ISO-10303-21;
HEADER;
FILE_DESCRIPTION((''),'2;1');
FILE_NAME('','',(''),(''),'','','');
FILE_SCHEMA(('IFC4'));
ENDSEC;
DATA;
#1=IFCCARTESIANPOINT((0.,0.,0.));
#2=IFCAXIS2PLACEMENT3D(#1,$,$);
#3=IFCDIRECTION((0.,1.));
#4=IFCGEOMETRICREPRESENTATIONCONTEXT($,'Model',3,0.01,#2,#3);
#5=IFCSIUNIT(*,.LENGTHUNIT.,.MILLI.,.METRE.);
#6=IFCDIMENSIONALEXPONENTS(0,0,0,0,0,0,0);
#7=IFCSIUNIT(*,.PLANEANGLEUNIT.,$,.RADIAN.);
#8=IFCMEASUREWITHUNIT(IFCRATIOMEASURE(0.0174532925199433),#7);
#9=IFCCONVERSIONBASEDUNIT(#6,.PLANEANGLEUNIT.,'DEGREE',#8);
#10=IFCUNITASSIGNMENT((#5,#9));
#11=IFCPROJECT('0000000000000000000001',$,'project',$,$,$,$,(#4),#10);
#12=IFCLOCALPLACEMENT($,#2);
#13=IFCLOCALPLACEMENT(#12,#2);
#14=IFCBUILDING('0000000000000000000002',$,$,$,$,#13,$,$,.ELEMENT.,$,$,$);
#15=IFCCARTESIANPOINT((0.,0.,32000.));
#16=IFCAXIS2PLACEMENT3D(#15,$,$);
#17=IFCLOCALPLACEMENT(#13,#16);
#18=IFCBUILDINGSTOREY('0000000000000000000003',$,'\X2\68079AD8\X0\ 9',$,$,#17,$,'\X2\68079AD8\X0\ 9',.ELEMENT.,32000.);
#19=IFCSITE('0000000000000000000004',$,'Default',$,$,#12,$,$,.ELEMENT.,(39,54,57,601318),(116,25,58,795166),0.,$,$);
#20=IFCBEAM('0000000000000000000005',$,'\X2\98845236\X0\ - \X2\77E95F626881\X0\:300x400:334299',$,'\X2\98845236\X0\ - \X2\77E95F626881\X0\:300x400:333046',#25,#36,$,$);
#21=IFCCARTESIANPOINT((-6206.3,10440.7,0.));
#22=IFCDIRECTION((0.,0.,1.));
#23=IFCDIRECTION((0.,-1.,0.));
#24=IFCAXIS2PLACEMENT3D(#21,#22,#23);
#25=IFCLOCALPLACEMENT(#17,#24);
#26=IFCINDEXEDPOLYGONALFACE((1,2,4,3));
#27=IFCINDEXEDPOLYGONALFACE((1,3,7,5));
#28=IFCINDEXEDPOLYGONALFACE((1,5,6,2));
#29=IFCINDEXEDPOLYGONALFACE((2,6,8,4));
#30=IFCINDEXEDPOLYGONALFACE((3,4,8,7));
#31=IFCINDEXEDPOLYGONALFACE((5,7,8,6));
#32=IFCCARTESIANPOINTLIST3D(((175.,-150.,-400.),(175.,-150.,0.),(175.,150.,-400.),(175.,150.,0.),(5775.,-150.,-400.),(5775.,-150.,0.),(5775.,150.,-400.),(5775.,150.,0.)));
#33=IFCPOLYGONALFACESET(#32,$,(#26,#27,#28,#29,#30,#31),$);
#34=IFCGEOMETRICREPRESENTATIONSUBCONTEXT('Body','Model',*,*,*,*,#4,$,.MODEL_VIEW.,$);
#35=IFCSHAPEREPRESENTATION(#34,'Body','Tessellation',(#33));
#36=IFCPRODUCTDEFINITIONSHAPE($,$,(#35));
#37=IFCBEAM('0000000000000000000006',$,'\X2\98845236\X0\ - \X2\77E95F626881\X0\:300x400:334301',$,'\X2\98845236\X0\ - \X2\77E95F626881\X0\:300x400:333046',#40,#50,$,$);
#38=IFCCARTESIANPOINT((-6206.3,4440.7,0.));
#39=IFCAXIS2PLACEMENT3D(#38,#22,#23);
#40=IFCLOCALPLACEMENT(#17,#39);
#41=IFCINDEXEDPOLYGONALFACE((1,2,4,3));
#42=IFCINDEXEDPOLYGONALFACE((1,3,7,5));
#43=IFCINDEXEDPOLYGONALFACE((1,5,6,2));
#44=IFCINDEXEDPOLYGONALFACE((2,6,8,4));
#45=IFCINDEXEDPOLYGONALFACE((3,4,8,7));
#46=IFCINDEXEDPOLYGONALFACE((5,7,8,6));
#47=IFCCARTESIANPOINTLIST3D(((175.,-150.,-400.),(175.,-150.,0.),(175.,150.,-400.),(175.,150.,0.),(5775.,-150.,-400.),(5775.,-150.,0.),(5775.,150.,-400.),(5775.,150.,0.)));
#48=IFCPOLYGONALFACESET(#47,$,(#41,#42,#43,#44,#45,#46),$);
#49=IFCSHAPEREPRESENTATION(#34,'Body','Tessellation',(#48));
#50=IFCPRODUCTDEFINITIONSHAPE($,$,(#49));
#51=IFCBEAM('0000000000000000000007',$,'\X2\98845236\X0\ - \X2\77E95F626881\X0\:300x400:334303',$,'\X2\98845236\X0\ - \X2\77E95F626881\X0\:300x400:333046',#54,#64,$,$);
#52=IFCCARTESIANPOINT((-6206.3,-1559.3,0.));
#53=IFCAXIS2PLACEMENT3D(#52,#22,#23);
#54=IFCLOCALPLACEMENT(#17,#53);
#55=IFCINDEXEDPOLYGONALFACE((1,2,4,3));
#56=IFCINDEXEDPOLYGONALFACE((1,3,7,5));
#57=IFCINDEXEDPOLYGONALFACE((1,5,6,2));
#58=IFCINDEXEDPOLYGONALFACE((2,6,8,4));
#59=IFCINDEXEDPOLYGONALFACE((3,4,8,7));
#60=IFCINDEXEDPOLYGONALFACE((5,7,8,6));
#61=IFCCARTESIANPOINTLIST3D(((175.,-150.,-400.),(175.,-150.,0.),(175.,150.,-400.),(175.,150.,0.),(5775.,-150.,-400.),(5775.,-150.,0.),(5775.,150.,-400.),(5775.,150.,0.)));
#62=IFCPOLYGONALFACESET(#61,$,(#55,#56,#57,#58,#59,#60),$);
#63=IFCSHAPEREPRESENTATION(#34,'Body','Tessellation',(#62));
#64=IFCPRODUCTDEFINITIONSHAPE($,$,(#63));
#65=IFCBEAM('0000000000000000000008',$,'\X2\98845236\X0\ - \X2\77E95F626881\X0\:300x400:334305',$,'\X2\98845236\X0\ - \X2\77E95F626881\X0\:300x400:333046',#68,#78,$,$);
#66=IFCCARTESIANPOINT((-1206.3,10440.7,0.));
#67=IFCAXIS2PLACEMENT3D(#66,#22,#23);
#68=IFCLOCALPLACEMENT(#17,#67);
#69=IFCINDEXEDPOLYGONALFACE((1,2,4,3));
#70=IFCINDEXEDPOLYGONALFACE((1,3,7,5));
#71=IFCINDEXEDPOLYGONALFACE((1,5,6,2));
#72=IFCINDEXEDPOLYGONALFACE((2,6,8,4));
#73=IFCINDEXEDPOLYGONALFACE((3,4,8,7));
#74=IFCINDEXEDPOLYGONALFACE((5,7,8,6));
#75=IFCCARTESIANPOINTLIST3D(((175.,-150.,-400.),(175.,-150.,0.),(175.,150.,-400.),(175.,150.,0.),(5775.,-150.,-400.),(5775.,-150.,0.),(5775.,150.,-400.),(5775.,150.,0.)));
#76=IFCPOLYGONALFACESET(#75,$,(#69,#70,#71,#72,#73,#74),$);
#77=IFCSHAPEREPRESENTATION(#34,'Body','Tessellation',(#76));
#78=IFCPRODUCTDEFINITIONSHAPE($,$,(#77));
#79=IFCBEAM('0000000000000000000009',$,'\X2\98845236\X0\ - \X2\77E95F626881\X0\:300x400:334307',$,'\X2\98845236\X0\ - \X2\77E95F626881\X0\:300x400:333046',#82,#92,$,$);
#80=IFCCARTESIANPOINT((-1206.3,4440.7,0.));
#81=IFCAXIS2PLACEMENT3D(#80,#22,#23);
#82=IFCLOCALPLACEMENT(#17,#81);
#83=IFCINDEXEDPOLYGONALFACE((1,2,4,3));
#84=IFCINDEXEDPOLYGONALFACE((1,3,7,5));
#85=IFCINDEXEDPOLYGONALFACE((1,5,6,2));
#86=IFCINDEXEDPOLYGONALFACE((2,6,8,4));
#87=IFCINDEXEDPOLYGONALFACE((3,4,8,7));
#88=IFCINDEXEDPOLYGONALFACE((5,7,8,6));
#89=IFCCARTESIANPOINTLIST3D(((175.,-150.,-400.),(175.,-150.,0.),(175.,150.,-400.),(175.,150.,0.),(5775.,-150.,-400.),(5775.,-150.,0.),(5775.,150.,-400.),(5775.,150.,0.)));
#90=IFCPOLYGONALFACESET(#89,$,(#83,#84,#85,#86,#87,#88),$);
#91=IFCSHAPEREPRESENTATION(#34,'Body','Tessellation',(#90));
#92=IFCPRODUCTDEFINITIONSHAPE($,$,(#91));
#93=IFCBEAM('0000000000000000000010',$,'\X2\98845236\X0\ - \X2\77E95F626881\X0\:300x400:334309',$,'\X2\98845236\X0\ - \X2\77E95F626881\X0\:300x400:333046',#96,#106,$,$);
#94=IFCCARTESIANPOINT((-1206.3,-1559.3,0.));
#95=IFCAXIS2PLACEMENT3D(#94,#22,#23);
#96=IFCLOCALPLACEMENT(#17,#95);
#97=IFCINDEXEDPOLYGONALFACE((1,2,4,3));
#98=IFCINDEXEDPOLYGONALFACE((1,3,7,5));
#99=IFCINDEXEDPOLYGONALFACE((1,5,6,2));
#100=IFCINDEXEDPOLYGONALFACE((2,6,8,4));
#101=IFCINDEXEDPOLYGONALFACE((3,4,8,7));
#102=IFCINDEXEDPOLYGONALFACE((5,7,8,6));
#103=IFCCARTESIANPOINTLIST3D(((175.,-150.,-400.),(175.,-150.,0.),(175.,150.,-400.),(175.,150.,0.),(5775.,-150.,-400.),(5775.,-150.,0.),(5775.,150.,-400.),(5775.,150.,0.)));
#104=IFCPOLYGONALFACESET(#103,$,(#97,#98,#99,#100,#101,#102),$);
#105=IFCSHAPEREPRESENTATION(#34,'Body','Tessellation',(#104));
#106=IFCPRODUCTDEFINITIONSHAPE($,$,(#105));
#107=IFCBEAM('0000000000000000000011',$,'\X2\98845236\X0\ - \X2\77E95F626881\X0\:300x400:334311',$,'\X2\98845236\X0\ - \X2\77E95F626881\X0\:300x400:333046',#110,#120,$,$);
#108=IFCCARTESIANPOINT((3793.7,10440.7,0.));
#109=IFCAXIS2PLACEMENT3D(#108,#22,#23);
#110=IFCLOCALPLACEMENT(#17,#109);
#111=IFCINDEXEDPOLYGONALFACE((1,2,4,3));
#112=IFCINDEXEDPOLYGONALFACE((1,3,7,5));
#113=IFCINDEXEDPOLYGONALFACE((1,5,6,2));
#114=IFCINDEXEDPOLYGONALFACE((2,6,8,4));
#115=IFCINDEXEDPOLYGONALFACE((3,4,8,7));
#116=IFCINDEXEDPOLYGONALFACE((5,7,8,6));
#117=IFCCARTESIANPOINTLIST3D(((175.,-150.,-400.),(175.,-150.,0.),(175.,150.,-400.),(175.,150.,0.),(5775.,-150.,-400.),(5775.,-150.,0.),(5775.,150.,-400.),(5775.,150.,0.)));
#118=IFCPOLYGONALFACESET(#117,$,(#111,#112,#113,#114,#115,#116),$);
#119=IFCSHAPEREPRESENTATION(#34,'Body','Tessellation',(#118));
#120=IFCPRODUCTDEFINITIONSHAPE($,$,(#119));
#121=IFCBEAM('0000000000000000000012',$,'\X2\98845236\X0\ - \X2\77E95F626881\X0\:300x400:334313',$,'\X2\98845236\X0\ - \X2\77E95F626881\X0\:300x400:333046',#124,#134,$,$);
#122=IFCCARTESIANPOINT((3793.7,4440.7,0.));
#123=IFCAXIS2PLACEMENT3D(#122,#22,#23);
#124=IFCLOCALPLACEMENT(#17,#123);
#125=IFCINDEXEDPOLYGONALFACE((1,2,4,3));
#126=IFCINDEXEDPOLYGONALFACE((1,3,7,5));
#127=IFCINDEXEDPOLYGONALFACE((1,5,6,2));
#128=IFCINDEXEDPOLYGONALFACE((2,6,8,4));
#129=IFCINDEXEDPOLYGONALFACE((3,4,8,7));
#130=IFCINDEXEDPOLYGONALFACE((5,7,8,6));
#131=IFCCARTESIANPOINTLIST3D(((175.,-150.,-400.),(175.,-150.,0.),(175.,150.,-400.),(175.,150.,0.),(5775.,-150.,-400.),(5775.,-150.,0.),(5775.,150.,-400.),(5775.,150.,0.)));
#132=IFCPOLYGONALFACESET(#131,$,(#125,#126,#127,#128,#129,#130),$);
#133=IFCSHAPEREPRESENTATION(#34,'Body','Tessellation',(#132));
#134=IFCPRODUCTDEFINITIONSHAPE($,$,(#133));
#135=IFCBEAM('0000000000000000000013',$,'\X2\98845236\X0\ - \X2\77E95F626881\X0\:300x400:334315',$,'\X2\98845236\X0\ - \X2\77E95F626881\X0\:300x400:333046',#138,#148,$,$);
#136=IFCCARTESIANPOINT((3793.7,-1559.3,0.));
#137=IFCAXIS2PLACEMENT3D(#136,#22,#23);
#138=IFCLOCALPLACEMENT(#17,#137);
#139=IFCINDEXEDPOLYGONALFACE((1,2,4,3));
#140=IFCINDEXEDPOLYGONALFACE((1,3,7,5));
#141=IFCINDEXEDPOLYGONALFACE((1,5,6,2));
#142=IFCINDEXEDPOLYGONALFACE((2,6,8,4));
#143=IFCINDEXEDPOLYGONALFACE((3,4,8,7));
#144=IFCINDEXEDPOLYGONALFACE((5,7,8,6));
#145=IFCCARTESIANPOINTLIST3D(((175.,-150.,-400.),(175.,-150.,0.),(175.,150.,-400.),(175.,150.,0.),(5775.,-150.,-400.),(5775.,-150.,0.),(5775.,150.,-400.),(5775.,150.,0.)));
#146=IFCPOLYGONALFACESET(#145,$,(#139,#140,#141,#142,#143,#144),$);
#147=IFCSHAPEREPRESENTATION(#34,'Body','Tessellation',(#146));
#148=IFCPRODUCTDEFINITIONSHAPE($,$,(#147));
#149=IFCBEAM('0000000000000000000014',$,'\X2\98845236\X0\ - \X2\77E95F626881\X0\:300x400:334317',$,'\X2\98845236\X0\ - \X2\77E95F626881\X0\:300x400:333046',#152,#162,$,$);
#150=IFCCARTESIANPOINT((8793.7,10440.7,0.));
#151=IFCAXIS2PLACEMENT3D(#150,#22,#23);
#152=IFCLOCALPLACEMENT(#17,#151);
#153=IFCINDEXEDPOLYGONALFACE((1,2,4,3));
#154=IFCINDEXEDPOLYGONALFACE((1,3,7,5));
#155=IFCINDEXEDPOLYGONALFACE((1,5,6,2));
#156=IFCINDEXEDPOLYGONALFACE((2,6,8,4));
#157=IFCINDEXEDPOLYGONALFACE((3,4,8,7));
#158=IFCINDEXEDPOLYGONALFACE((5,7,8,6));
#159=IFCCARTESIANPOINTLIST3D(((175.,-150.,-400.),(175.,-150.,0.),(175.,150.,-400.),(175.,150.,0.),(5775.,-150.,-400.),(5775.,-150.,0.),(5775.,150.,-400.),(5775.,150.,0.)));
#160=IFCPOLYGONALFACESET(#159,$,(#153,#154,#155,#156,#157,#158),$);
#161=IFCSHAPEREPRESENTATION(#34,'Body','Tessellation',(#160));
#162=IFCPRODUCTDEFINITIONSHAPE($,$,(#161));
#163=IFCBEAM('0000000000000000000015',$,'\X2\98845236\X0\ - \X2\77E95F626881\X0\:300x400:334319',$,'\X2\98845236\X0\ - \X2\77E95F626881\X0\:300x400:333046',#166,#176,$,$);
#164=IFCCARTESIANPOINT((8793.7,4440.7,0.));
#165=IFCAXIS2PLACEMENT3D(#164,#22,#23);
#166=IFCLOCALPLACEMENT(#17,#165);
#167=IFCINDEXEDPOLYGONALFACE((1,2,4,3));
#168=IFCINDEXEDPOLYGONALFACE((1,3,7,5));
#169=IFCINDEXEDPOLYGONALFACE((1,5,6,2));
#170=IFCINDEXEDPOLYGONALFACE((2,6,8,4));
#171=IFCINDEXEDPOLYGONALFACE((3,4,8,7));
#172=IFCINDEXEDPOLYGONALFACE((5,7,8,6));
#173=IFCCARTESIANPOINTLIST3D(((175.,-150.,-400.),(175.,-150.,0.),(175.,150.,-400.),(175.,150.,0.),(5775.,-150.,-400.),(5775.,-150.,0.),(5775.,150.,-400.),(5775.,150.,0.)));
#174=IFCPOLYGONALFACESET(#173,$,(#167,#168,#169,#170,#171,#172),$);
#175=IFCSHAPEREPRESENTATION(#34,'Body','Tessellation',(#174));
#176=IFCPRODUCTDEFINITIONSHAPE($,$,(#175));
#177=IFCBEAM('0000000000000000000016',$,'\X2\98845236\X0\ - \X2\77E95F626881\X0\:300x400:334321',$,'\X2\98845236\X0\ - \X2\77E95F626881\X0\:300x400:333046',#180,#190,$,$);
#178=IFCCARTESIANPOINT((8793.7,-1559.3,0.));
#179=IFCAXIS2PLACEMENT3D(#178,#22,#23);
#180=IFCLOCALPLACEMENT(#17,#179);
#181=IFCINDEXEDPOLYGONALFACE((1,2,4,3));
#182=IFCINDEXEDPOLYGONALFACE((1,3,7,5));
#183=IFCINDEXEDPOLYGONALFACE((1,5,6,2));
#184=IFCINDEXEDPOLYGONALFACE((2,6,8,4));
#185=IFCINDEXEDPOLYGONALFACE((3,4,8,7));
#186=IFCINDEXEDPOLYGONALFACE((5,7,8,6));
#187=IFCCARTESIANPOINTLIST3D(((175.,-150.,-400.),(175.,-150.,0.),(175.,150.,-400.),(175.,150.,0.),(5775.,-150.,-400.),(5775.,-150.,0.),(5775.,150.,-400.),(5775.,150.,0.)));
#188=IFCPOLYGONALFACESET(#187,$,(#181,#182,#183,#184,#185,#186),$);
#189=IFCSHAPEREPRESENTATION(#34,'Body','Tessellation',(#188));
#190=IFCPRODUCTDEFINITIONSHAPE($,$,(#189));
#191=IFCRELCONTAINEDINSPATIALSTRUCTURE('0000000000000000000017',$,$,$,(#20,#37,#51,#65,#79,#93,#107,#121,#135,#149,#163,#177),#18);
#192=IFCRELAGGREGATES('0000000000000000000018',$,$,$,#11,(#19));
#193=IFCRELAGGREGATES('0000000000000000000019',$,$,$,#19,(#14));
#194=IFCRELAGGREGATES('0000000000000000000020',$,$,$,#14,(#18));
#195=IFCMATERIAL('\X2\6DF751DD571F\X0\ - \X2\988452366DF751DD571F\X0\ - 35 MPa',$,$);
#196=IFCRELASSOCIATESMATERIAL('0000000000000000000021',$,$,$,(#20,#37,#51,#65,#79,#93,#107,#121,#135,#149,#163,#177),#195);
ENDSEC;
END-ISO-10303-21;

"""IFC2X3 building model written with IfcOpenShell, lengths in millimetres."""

from ifc_helpers import new_model, entity, si_unit, converted_unit, direction, frame, frame_2d, origin, origin_2d_with_axis, place, context, subcontext, project, spatial, rectangle, extrude, material, element, save


model = new_model("IFC2X3")

# Units and contexts
model_context = context("Model", 3, precision=0.01, world=origin(), true_north=direction((0.0, 1.0)))
body_context = subcontext(model_context, "Body", "Model", "MODEL_VIEW")
ifc_project = project(units=[si_unit("LENGTHUNIT", "METRE", prefix="MILLI"), converted_unit("PLANEANGLEUNIT", "DEGREE", entity("IfcRatioMeasure", 0.0174532925199433), si_unit("PLANEANGLEUNIT", "RADIAN"), dimensions=[0, 0, 0, 0, 0, 0, 0])], contexts=[model_context])

# Site, building, storey
site_placement = place(None, origin())
site = spatial("IfcSite", under=ifc_project, at=site_placement, Name="Default", CompositionType="ELEMENT", RefLatitude=(39, 54, 57, 601318), RefLongitude=(116, 25, 58, 795166), RefElevation=0.0)
building_placement = place(site_placement, origin())
building = spatial("IfcBuilding", under=site, at=building_placement, CompositionType="ELEMENT")
storey_placement = place(building_placement, frame((0.0, 0.0, 32000.0)))
storey = spatial("IfcBuildingStorey", under=building, at=storey_placement, Name="标高 9", LongName="标高 9", CompositionType="ELEMENT", Elevation=32000.0)

# Beams
ifc_material_1 = material(Name="混凝土 - 预制混凝土 - 35 MPa")
for number, where, z_axis, x_axis, name in (
    (1, (-6206.3, 10440.7, 0.0), (0.0, 0.0, 1.0), (0.0, -1.0, 0.0), "预制 - 矩形梁:300x400:334299"),
    (2, (-6206.3, 4440.7, 0.0), (0.0, 0.0, 1.0), (0.0, -1.0, 0.0), "预制 - 矩形梁:300x400:334301"),
    (3, (-6206.3, -1559.3, 0.0), (0.0, 0.0, 1.0), (0.0, -1.0, 0.0), "预制 - 矩形梁:300x400:334303"),
):
    element("IfcBeam", number, at=place(storey_placement, frame(where, z_axis=z_axis, x_axis=x_axis)), inside=storey, material=ifc_material_1, Name=name, ObjectType="预制 - 矩形梁:300x400:333046", context=body_context, shape_type="SweptSolid", body=[
        extrude(rectangle(XDim=400.0, YDim=300.0, at=origin_2d_with_axis()), frame((175.0, 0.0, -200.0), z_axis=(1.0, 0.0, 0.0), x_axis=(0.0, 0.0, -1.0)), (0.0, 0.0, 1.0), 5600.0),
    ])
beam_1_placement = place(storey_placement, frame((-1206.3, 10440.7, 0.0), z_axis=(0.0, 0.0, 1.0), x_axis=(0.0, -1.0, 0.0)))
element("IfcBeam", 4, at=beam_1_placement, inside=storey, material=ifc_material_1, Name="预制 - 矩形梁:300x400:334305", ObjectType="预制 - 矩形梁:300x400:333046", context=body_context, shape_type="SweptSolid", body=[
    extrude(rectangle(XDim=400.0, YDim=300.0, at=frame_2d((0.0, 0.0), x_axis=(1.0, 0.0))), frame((175.0, 0.0, -200.0), z_axis=(1.0, 0.0, 0.0), x_axis=(0.0, 0.0, -1.0)), (0.0, 0.0, 1.0), 5600.0),
])
beam_2_placement = place(storey_placement, frame((-1206.3, 4440.7, 0.0), z_axis=(0.0, 0.0, 1.0), x_axis=(0.0, -1.0, 0.0)))
element("IfcBeam", 5, at=beam_2_placement, inside=storey, material=ifc_material_1, Name="预制 - 矩形梁:300x400:334307", ObjectType="预制 - 矩形梁:300x400:333046", context=body_context, shape_type="SweptSolid", body=[
    extrude(rectangle(XDim=400.0, YDim=300.0, at=frame_2d((0.0, 0.0), x_axis=(1.0, 0.0))), frame((175.0, 0.0, -200.0), z_axis=(1.0, 0.0, 0.0), x_axis=(0.0, 0.0, -1.0)), (0.0, 0.0, 1.0), 5600.0),
])
beam_3_placement = place(storey_placement, frame((-1206.3, -1559.3, 0.0), z_axis=(0.0, 0.0, 1.0), x_axis=(0.0, -1.0, 0.0)))
element("IfcBeam", 6, at=beam_3_placement, inside=storey, material=ifc_material_1, Name="预制 - 矩形梁:300x400:334309", ObjectType="预制 - 矩形梁:300x400:333046", context=body_context, shape_type="SweptSolid", body=[
    extrude(rectangle(XDim=400.0, YDim=300.0, at=frame_2d((0.0, 0.0), x_axis=(1.0, 0.0))), frame((175.0, 0.0, -200.0), z_axis=(1.0, 0.0, 0.0), x_axis=(0.0, 0.0, -1.0)), (0.0, 0.0, 1.0), 5600.0),
])
beam_4_placement = place(storey_placement, frame((3793.7, 10440.7, 0.0), z_axis=(0.0, 0.0, 1.0), x_axis=(0.0, -1.0, 0.0)))
element("IfcBeam", 7, at=beam_4_placement, inside=storey, material=ifc_material_1, Name="预制 - 矩形梁:300x400:334311", ObjectType="预制 - 矩形梁:300x400:333046", context=body_context, shape_type="SweptSolid", body=[
    extrude(rectangle(XDim=400.0, YDim=300.0, at=frame_2d((0.0, 0.0), x_axis=(1.0, 0.0))), frame((175.0, 0.0, -200.0), z_axis=(1.0, 0.0, 0.0), x_axis=(0.0, 0.0, -1.0)), (0.0, 0.0, 1.0), 5600.0),
])
beam_5_placement = place(storey_placement, frame((3793.7, 4440.7, 0.0), z_axis=(0.0, 0.0, 1.0), x_axis=(0.0, -1.0, 0.0)))
element("IfcBeam", 8, at=beam_5_placement, inside=storey, material=ifc_material_1, Name="预制 - 矩形梁:300x400:334313", ObjectType="预制 - 矩形梁:300x400:333046", context=body_context, shape_type="SweptSolid", body=[
    extrude(rectangle(XDim=400.0, YDim=300.0, at=origin_2d_with_axis()), frame((175.0, 0.0, -200.0), z_axis=(1.0, 0.0, 0.0), x_axis=(0.0, 0.0, -1.0)), (0.0, 0.0, 1.0), 5600.0),
])
beam_6_placement = place(storey_placement, frame((3793.7, -1559.3, 0.0), z_axis=(0.0, 0.0, 1.0), x_axis=(0.0, -1.0, 0.0)))
element("IfcBeam", 9, at=beam_6_placement, inside=storey, material=ifc_material_1, Name="预制 - 矩形梁:300x400:334315", ObjectType="预制 - 矩形梁:300x400:333046", context=body_context, shape_type="SweptSolid", body=[
    extrude(rectangle(XDim=400.0, YDim=300.0, at=frame_2d((0.0, 0.0), x_axis=(1.0, 0.0))), frame((175.0, 0.0, -200.0), z_axis=(1.0, 0.0, 0.0), x_axis=(0.0, 0.0, -1.0)), (0.0, 0.0, 1.0), 5600.0),
])
for number, where, z_axis, x_axis, name in (
    (10, (8793.7, 10440.7, 0.0), (0.0, 0.0, 1.0), (0.0, -1.0, 0.0), "预制 - 矩形梁:300x400:334317"),
    (11, (8793.7, 4440.7, 0.0), (0.0, 0.0, 1.0), (0.0, -1.0, 0.0), "预制 - 矩形梁:300x400:334319"),
    (12, (8793.7, -1559.3, 0.0), (0.0, 0.0, 1.0), (0.0, -1.0, 0.0), "预制 - 矩形梁:300x400:334321"),
):
    element("IfcBeam", number, at=place(storey_placement, frame(where, z_axis=z_axis, x_axis=x_axis)), inside=storey, material=ifc_material_1, Name=name, ObjectType="预制 - 矩形梁:300x400:333046", context=body_context, shape_type="SweptSolid", body=[
        extrude(rectangle(XDim=400.0, YDim=300.0, at=origin_2d_with_axis()), frame((175.0, 0.0, -200.0), z_axis=(1.0, 0.0, 0.0), x_axis=(0.0, 0.0, -1.0)), (0.0, 0.0, 1.0), 5600.0),
    ])

save(model, "model.ifc")
